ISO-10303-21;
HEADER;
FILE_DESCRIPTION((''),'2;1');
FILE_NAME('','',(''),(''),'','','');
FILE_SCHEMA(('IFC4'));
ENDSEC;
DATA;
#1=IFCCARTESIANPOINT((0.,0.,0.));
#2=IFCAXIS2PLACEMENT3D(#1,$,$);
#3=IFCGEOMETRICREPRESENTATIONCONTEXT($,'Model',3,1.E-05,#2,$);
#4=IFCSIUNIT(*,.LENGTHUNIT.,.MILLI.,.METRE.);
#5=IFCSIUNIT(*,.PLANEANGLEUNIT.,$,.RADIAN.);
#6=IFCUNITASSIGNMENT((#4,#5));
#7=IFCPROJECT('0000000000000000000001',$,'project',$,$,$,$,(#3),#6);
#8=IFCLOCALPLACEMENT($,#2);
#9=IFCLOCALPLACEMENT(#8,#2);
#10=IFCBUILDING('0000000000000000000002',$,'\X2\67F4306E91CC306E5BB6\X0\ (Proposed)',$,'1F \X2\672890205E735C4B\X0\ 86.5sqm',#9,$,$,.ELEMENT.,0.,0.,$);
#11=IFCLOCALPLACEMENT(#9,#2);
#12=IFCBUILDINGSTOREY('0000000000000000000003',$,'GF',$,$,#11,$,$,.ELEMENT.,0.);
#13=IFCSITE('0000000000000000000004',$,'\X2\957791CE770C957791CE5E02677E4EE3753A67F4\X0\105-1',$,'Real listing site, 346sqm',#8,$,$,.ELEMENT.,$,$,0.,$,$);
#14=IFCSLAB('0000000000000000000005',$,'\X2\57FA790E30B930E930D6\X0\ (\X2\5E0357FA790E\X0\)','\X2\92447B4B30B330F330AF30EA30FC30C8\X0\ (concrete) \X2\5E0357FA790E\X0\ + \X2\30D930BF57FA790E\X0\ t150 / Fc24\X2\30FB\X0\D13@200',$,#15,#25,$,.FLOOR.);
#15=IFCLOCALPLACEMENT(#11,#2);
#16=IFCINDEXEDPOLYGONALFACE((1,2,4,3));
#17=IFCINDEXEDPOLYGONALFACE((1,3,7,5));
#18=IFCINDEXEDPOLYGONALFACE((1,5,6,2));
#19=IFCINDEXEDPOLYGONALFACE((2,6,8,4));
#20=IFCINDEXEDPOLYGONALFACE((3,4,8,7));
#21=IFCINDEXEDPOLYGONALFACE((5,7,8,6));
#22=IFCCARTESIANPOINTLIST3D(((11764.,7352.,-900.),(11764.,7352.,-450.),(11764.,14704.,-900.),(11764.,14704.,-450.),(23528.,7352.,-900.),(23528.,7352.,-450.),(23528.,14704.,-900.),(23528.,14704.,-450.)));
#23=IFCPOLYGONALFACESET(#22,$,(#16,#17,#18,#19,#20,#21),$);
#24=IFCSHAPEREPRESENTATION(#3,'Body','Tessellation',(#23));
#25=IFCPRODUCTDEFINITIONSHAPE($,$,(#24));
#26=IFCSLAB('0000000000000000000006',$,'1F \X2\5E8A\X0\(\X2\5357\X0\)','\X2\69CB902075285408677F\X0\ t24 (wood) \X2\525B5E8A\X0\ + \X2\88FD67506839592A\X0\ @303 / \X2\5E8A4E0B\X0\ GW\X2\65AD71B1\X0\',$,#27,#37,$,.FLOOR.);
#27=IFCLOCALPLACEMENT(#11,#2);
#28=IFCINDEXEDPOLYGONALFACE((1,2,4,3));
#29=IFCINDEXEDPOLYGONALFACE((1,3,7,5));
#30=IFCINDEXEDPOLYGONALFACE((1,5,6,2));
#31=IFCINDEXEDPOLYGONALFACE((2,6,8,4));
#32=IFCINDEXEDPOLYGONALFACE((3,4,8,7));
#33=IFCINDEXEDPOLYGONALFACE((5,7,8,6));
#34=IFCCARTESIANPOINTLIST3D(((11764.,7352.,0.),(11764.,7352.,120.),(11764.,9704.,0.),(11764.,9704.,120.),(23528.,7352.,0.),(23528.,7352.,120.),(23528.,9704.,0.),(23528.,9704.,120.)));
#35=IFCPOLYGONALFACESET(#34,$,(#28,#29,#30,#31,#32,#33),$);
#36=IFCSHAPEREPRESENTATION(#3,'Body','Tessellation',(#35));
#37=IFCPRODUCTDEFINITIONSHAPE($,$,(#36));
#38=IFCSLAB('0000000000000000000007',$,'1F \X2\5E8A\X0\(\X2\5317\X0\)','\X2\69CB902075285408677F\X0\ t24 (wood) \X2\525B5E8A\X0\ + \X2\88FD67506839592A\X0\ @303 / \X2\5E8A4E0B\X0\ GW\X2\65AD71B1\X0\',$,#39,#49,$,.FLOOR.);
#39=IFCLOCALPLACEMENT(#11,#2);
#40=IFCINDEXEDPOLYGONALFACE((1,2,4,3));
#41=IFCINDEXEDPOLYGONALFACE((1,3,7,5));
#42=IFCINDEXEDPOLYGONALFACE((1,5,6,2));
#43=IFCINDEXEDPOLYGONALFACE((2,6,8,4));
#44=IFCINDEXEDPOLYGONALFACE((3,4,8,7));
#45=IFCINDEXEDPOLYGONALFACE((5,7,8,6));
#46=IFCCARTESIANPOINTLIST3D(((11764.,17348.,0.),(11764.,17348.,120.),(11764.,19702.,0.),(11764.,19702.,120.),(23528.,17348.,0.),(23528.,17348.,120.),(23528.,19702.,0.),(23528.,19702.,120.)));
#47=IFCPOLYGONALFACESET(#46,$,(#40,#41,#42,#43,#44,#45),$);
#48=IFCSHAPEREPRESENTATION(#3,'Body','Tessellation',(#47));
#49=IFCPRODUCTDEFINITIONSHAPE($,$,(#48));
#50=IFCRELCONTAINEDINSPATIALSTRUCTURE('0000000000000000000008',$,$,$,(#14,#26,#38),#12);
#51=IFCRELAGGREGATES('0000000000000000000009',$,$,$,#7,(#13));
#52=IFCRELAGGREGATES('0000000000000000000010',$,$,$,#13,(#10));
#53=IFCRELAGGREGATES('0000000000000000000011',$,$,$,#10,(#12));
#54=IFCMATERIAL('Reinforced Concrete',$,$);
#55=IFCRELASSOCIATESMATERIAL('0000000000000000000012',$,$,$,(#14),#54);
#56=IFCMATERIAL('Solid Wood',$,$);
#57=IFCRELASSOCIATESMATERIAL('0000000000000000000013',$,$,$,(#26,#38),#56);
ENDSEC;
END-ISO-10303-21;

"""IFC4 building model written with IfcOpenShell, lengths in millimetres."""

from ifc_helpers import new_model, si_unit, frame, frame_2d, origin, place, context, project, spatial, rectangle, extrude, material, element, save


model = new_model("IFC4")

# Units and contexts
model_context = context("Model", 3, precision=1e-05, world=origin())
ifc_project = project(units=[si_unit("LENGTHUNIT", "METRE", prefix="MILLI"), si_unit("PLANEANGLEUNIT", "RADIAN")], contexts=[model_context])

# Site, building, storey
site_placement = place(None, origin())
site = spatial("IfcSite", under=ifc_project, at=site_placement, Name="長野県長野市松代町柴105-1", ObjectType="Real listing site, 346sqm", CompositionType="ELEMENT", RefElevation=0.0)
building_placement = place(site_placement, origin())
building = spatial("IfcBuilding", under=site, at=building_placement, Name="柴の里の家 (Proposed)", ObjectType="1F 木造平屋 86.5sqm", CompositionType="ELEMENT", ElevationOfRefHeight=0.0, ElevationOfTerrain=0.0)
storey_placement = place(building_placement, origin())
storey = spatial("IfcBuildingStorey", under=building, at=storey_placement, Name="GF", CompositionType="ELEMENT", Elevation=0.0)

# Slabs
ifc_material_1 = material(Name="Reinforced Concrete")
slab_1_placement = place(storey_placement, frame((5882.0, 3676.0, -450.0)))
element("IfcSlab", 1, at=slab_1_placement, inside=storey, material=ifc_material_1, Name="基礎スラブ (布基礎)", Description="鉄筋コンクリート (concrete) 布基礎 + ベタ基礎 t150 / Fc24・D13@200", PredefinedType="FLOOR", context=model_context, shape_type="SweptSolid", body=[
    extrude(rectangle(XDim=11764.0, YDim=7352.0, at=frame_2d((5882.0, 3676.0))), frame((5882.0, 3676.0, -450.0)), (0.0, 0.0, 1.0), 450.0),
])
ifc_material_2 = material(Name="Solid Wood")
slab_2_placement = place(storey_placement, frame((5882.0, 3676.0, 0.0)))
element("IfcSlab", 2, at=slab_2_placement, inside=storey, material=ifc_material_2, Name="1F 床(南)", Description="構造用合板 t24 (wood) 剛床 + 製材根太 @303 / 床下 GW断熱", PredefinedType="FLOOR", context=model_context, shape_type="SweptSolid", body=[
    extrude(rectangle(XDim=11764.0, YDim=2352.0, at=frame_2d((5882.0, 1176.0))), frame((5882.0, 3676.0, 0.0)), (0.0, 0.0, 1.0), 120.0),
])
slab_3_placement = place(storey_placement, frame((5882.0, 8674.0, 0.0)))
element("IfcSlab", 3, at=slab_3_placement, inside=storey, material=ifc_material_2, Name="1F 床(北)", Description="構造用合板 t24 (wood) 剛床 + 製材根太 @303 / 床下 GW断熱", PredefinedType="FLOOR", context=model_context, shape_type="SweptSolid", body=[
    extrude(rectangle(XDim=11764.0, YDim=2354.0, at=frame_2d((5882.0, 1177.0))), frame((5882.0, 8674.0, 0.0)), (0.0, 0.0, 1.0), 120.0),
])

save(model, "model.ifc")
